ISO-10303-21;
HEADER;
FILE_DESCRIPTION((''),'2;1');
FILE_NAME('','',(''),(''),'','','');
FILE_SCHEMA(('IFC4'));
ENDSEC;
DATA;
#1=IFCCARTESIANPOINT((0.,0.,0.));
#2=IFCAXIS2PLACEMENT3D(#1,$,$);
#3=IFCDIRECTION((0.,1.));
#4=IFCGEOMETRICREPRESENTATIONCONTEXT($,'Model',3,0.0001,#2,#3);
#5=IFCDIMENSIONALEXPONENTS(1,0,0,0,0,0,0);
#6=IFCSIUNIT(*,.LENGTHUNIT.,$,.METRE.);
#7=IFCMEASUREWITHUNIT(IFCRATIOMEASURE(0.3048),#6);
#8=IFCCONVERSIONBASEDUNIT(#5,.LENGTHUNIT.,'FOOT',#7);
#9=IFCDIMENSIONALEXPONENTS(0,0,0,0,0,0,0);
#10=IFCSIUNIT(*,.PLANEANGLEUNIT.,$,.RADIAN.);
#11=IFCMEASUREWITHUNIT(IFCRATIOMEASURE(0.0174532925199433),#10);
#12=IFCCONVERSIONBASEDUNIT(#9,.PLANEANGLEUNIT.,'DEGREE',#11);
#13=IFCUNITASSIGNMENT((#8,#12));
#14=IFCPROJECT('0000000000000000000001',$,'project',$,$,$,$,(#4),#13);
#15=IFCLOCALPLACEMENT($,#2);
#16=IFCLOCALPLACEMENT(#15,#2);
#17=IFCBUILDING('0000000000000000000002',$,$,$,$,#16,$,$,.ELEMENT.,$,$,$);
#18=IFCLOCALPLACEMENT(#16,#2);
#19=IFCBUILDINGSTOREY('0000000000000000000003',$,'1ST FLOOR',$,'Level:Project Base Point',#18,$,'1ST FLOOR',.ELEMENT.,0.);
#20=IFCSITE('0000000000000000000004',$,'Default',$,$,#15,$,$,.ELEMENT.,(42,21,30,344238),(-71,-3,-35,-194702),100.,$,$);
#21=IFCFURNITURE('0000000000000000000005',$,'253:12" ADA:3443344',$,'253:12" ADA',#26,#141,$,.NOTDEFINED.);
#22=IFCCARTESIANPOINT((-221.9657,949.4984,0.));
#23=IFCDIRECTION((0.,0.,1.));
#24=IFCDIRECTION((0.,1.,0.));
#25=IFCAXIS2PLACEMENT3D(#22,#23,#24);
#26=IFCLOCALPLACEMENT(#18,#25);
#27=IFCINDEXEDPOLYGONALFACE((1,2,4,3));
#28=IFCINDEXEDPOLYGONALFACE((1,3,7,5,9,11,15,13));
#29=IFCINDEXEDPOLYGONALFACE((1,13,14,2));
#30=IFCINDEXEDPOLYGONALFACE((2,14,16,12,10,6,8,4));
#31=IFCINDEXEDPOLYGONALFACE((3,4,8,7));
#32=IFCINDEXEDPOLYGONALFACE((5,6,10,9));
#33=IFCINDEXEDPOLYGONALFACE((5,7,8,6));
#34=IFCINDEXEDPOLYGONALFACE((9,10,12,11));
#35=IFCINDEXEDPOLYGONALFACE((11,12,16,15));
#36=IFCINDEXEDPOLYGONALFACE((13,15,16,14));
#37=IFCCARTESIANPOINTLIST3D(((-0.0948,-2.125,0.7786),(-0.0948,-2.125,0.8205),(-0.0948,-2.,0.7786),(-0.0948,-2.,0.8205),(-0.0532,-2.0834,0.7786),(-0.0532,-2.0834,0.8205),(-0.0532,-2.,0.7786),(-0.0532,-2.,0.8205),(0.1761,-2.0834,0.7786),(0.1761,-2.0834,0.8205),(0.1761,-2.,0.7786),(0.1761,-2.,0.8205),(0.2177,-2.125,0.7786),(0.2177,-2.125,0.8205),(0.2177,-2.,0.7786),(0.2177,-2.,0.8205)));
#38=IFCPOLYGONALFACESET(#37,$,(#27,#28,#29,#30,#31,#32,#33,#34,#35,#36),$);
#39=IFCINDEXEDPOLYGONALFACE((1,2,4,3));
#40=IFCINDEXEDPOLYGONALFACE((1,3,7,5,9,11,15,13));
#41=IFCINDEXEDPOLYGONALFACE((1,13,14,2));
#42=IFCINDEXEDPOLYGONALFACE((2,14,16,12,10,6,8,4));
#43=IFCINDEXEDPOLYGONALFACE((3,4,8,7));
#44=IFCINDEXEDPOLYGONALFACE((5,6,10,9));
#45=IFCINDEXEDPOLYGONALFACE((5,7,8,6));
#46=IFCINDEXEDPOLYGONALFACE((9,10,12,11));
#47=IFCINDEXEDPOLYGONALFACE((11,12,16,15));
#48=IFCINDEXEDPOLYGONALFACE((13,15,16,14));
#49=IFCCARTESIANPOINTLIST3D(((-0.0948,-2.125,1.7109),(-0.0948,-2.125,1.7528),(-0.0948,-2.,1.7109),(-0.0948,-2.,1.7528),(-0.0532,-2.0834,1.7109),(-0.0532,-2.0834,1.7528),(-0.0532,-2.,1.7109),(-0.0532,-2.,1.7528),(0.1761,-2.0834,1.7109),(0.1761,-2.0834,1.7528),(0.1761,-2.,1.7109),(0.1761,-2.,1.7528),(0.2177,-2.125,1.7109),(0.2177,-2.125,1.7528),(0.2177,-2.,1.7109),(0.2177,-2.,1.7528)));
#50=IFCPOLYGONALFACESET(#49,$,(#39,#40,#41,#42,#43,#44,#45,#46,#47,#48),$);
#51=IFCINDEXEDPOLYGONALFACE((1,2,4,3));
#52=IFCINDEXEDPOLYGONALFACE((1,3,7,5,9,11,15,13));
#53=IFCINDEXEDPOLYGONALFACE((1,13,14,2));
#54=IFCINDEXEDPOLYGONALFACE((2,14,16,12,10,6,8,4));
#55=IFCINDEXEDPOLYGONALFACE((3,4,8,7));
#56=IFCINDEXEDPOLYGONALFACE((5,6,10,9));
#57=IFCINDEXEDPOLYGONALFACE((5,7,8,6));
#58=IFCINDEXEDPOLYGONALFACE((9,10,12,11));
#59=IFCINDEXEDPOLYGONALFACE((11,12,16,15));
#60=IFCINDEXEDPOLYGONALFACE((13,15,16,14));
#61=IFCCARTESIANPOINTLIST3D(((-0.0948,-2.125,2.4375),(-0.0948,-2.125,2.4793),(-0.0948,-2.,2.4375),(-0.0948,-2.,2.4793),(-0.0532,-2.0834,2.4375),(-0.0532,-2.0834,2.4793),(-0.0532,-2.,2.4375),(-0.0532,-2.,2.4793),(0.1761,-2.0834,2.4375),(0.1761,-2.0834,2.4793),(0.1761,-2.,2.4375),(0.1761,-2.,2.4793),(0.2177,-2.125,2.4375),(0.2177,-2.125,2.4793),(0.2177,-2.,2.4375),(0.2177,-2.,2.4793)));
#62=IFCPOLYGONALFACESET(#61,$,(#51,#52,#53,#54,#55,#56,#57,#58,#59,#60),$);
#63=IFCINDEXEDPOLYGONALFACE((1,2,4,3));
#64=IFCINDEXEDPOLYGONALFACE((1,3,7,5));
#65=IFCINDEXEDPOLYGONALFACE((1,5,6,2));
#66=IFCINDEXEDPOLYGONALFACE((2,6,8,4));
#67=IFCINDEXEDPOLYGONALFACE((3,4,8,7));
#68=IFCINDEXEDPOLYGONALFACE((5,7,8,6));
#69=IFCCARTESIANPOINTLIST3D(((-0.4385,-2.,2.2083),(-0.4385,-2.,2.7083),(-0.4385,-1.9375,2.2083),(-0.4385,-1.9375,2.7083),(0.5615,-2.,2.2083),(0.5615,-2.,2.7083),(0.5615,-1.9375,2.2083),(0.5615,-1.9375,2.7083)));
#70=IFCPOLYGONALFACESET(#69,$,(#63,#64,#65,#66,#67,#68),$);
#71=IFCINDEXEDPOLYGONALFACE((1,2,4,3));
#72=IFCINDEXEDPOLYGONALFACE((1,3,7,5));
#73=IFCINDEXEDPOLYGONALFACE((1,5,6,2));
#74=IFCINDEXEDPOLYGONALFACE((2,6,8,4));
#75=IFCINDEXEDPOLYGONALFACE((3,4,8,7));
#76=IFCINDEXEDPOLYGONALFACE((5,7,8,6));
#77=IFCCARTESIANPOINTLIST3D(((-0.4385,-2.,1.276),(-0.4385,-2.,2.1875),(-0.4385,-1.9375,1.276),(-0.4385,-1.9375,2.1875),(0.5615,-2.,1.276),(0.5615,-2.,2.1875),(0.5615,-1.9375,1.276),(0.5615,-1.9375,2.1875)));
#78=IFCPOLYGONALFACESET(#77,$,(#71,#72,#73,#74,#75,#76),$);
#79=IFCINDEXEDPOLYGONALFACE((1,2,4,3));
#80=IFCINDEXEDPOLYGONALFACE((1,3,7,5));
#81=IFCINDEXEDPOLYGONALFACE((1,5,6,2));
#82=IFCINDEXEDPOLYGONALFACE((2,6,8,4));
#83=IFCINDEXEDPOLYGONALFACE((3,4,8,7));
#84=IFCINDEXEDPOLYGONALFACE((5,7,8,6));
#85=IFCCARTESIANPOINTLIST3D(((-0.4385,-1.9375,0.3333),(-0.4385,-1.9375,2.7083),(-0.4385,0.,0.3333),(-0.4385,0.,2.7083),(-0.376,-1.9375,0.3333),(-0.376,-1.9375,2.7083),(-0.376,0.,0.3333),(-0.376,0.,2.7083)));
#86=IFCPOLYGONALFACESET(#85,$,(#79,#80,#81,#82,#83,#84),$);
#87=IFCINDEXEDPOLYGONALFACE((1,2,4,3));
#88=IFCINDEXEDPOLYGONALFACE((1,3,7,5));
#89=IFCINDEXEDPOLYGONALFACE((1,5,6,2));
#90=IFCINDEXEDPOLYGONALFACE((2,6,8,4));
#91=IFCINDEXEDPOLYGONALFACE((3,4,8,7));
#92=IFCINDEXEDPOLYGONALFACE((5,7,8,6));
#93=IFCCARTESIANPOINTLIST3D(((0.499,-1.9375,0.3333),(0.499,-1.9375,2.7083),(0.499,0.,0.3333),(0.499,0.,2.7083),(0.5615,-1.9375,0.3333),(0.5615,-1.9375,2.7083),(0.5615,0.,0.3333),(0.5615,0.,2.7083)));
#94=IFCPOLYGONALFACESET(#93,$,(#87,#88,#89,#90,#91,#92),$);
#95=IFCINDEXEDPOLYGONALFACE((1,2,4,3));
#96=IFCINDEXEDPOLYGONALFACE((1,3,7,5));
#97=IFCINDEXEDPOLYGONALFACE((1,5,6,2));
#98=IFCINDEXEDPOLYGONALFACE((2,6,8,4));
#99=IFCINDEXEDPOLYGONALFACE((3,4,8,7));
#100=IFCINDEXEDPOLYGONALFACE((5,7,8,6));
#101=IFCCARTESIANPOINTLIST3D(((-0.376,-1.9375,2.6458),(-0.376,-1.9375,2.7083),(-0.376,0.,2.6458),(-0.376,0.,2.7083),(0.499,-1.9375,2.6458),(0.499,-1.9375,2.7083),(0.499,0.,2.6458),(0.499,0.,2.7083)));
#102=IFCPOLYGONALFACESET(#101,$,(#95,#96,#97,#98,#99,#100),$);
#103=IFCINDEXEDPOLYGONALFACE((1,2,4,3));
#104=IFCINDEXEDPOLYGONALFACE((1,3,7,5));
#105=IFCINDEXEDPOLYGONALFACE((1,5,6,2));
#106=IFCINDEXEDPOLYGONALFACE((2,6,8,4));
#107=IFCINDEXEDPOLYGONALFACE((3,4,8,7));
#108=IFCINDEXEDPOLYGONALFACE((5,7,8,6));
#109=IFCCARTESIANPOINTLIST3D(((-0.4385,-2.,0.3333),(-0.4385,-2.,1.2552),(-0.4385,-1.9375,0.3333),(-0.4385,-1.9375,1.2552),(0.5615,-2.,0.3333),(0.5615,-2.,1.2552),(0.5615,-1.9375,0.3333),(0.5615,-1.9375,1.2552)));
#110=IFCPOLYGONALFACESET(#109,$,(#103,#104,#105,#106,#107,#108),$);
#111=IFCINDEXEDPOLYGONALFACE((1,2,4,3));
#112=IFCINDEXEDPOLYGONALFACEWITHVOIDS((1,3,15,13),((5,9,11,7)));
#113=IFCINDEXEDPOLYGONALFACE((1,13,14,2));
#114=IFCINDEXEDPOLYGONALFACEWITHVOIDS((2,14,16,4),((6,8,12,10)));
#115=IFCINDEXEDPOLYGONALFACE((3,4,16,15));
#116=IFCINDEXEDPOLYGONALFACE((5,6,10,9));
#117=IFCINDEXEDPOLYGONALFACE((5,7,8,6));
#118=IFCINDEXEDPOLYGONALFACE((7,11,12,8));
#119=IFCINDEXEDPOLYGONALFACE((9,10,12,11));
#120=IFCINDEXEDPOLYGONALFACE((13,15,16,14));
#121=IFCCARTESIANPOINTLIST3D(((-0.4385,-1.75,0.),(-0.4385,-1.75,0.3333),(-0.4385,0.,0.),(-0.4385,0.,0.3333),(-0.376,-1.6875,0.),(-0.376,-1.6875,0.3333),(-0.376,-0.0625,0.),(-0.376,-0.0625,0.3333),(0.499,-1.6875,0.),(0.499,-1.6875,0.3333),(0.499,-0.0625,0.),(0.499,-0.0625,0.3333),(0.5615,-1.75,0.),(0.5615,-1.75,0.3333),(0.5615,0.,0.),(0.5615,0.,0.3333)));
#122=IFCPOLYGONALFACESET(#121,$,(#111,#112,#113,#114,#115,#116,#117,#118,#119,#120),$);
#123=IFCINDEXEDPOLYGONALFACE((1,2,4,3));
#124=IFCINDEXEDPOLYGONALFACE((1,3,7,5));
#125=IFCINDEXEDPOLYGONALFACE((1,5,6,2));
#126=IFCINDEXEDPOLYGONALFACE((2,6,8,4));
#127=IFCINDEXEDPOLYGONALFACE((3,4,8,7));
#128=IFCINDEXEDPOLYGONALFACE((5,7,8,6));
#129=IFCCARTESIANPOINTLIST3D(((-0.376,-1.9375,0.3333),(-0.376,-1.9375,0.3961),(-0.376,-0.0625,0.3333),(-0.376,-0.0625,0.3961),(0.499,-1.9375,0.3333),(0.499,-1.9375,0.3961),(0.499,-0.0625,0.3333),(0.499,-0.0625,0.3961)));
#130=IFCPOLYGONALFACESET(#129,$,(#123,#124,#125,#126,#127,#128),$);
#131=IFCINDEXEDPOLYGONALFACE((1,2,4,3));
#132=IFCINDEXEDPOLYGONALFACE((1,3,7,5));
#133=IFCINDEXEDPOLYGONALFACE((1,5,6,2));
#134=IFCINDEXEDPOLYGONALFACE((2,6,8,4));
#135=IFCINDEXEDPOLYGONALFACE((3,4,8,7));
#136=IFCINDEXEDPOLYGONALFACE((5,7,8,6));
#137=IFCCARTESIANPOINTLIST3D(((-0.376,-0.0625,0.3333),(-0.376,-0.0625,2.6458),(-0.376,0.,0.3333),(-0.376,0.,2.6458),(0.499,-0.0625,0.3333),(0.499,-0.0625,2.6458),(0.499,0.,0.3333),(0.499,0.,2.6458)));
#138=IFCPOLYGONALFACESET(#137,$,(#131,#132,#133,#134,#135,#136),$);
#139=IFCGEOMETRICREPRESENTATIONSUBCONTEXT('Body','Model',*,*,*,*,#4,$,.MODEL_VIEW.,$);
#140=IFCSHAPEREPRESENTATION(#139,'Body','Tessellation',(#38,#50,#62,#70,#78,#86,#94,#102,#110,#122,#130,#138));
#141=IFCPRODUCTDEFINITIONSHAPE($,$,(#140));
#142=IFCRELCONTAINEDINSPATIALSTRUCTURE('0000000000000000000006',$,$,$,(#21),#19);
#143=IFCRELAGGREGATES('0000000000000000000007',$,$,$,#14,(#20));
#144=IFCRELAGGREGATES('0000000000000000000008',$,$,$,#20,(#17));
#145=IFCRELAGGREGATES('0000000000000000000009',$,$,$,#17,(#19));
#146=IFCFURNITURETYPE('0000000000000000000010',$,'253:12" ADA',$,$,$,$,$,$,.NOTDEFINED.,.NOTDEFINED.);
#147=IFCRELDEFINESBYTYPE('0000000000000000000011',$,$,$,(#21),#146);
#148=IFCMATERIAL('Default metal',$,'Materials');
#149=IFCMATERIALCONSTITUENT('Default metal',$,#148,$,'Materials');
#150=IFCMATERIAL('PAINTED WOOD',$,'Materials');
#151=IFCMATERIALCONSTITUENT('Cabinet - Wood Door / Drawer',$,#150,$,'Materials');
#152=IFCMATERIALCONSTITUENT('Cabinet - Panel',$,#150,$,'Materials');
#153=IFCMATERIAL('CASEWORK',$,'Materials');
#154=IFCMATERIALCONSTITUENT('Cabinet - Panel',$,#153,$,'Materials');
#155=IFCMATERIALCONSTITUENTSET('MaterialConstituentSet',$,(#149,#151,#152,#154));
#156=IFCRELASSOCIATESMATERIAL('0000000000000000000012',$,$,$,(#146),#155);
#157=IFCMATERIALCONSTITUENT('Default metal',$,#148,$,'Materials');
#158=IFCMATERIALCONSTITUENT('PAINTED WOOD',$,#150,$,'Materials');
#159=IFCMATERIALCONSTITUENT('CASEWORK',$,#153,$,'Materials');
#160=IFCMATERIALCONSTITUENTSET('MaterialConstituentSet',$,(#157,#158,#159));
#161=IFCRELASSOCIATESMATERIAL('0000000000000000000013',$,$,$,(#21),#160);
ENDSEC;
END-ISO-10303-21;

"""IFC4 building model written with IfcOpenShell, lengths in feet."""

from ifc_helpers import new_model, entity, si_unit, converted_unit, direction, frame, frame_2d, origin, origin_2d_with_axis, place, context, subcontext, project, spatial, polyline, rectangle, outline, extrude, source, transform, mapped, material, constituent, constituent_set, type_object, type_shapes, element, save


model = new_model("IFC4")

# Units and contexts
model_context = context("Model", 3, precision=0.0001, world=origin(), true_north=direction((0.0, 1.0)))
body_context = subcontext(model_context, "Body", "Model", "MODEL_VIEW")
ifc_project = project(units=[converted_unit("LENGTHUNIT", "FOOT", entity("IfcRatioMeasure", 0.3048), si_unit("LENGTHUNIT", "METRE"), dimensions=[1, 0, 0, 0, 0, 0, 0]), converted_unit("PLANEANGLEUNIT", "DEGREE", entity("IfcRatioMeasure", 0.0174532925199433), si_unit("PLANEANGLEUNIT", "RADIAN"), dimensions=[0, 0, 0, 0, 0, 0, 0])], contexts=[model_context])

# Site, building, storey
site_placement = place(None, origin())
site = spatial("IfcSite", under=ifc_project, at=site_placement, Name="Default", CompositionType="ELEMENT", RefLatitude=(42, 21, 30, 344238), RefLongitude=(-71, -3, -35, -194702), RefElevation=100.0)
building_placement = place(site_placement, origin())
building = spatial("IfcBuilding", under=site, at=building_placement, CompositionType="ELEMENT")
storey_placement = place(building_placement, origin())
storey = spatial("IfcBuildingStorey", under=building, at=storey_placement, Name="1ST FLOOR", ObjectType="Level:Project Base Point", LongName="1ST FLOOR", CompositionType="ELEMENT", Elevation=0.0)

# Furniture
ifc_material_1 = material(Name="Default metal", Category="Materials")
ifc_constituent_1 = constituent(ifc_material_1, Name="Default metal", Category="Materials")
ifc_material_2 = material(Name="PAINTED WOOD", Category="Materials")
ifc_constituent_2 = constituent(ifc_material_2, Name="PAINTED WOOD", Category="Materials")
ifc_material_3 = material(Name="CASEWORK", Category="Materials")
ifc_constituent_3 = constituent(ifc_material_3, Name="CASEWORK", Category="Materials")
ifc_constituent_set_1 = constituent_set(constituents=[ifc_constituent_1, ifc_constituent_2, ifc_constituent_3], Name="MaterialConstituentSet")
ifc_constituent_4 = constituent(ifc_material_1, Name="Default metal", Category="Materials")
ifc_constituent_5 = constituent(ifc_material_2, Name="Cabinet - Wood Door / Drawer", Category="Materials")
ifc_constituent_6 = constituent(ifc_material_2, Name="Cabinet - Panel", Category="Materials")
ifc_constituent_7 = constituent(ifc_material_3, Name="Cabinet - Panel", Category="Materials")
ifc_constituent_set_2 = constituent_set(constituents=[ifc_constituent_4, ifc_constituent_5, ifc_constituent_6, ifc_constituent_7], Name="MaterialConstituentSet")
furniture_type_1 = type_object("IfcFurnitureType", Name="253:12\" ADA", AssemblyPlace="NOTDEFINED", PredefinedType="NOTDEFINED", material=ifc_constituent_set_2)
shared_shape_1 = source(origin(), body_context, "Body", "SweptSolid", [
    extrude(outline(polyline([(-0.0521, -0.1562), (0.0729, -0.1562), (0.0729, 0.1562), (-0.0521, 0.1562), (-0.0521, 0.1146), (0.0313, 0.1146), (0.0313, -0.1146), (-0.0521, -0.1146), (-0.0521, -0.1562)])), frame((0.0615, -2.0521, 0.7786), z_axis=(0.0, 0.0, 1.0), x_axis=(0.0, -1.0, 0.0)), (0.0, 0.0, 1.0), 0.0418),
    extrude(outline(polyline([(-0.0521, -0.1562), (0.0729, -0.1562), (0.0729, 0.1562), (-0.0521, 0.1562), (-0.0521, 0.1146), (0.0313, 0.1146), (0.0313, -0.1146), (-0.0521, -0.1146), (-0.0521, -0.1562)])), frame((0.0615, -2.0521, 1.7109), z_axis=(0.0, 0.0, 1.0), x_axis=(0.0, -1.0, 0.0)), (0.0, 0.0, 1.0), 0.0418),
    extrude(outline(polyline([(-0.0521, -0.1562), (0.0729, -0.1562), (0.0729, 0.1562), (-0.0521, 0.1562), (-0.0521, 0.1146), (0.0313, 0.1146), (0.0313, -0.1146), (-0.0521, -0.1146), (-0.0521, -0.1562)])), frame((0.0615, -2.0521, 2.4375), z_axis=(0.0, 0.0, 1.0), x_axis=(0.0, -1.0, 0.0)), (0.0, 0.0, 1.0), 0.0418),
    extrude(rectangle(XDim=0.0625, YDim=1.0, at=origin_2d_with_axis()), frame((0.0615, -1.9688, 2.2083), z_axis=(0.0, 0.0, 1.0), x_axis=(0.0, 1.0, 0.0)), (0.0, 0.0, 1.0), 0.5),
    extrude(rectangle(XDim=0.0625, YDim=1.0, at=origin_2d_with_axis()), frame((0.0615, -1.9688, 1.276), z_axis=(0.0, 0.0, 1.0), x_axis=(0.0, 1.0, 0.0)), (0.0, 0.0, 1.0), 0.9115),
    extrude(rectangle(XDim=0.0625, YDim=1.9375, at=frame_2d((0.0, 0.0), x_axis=(1.0, 0.0))), frame((-0.4073, -0.9687, 0.3333)), (0.0, 0.0, 1.0), 2.375),
    extrude(rectangle(XDim=0.0625, YDim=1.9375, at=frame_2d((0.0, 0.0), x_axis=(1.0, 0.0))), frame((0.5302, -0.9687, 0.3333)), (0.0, 0.0, 1.0), 2.375),
    extrude(rectangle(XDim=0.875, YDim=1.9375, at=origin_2d_with_axis()), frame((0.0615, -0.9688, 2.6458), z_axis=(0.0, 0.0, 1.0), x_axis=(-1.0, 0.0, 0.0)), (0.0, 0.0, 1.0), 0.0625),
    extrude(rectangle(XDim=0.0625, YDim=1.0, at=origin_2d_with_axis()), frame((0.0615, -1.9688, 0.3333), z_axis=(0.0, 0.0, 1.0), x_axis=(0.0, 1.0, 0.0)), (0.0, 0.0, 1.0), 0.9219),
    extrude(outline(polyline([(-0.5, -0.875), (0.5, -0.875), (0.5, 0.875), (-0.5, 0.875), (-0.5, -0.875)]), holes=[polyline([(-0.4375, -0.8125), (-0.4375, 0.8125), (0.4375, 0.8125), (0.4375, -0.8125), (-0.4375, -0.8125)])]), frame((0.0615, -0.875, 0.0)), (0.0, 0.0, 1.0), 0.3333),
    extrude(rectangle(XDim=0.875, YDim=1.875, at=frame_2d((0.0, 0.0), x_axis=(1.0, 0.0))), frame((0.0615, -1.0, 0.3333), z_axis=(0.0, 0.0, 1.0), x_axis=(-1.0, 0.0, 0.0)), (0.0, 0.0, 1.0), 0.0627),
    extrude(rectangle(XDim=0.0625, YDim=0.875, at=origin_2d_with_axis()), frame((0.0615, -0.0312, 0.3333), z_axis=(0.0, 0.0, 1.0), x_axis=(0.0, 1.0, 0.0)), (0.0, 0.0, 1.0), 2.3125),
])
type_shapes(furniture_type_1, [shared_shape_1])
furniture_1_placement = place(storey_placement, frame((-221.9657, 949.4984, 0.0), z_axis=(0.0, 0.0, 1.0), x_axis=(0.0, 1.0, 0.0)))
element("IfcFurniture", 1, at=furniture_1_placement, inside=storey, type_object=furniture_type_1, material=ifc_constituent_set_1, Name="253:12\" ADA:3443344", ObjectType="253:12\" ADA", PredefinedType="NOTDEFINED", context=body_context, shape_type="MappedRepresentation", body=[
    mapped(shared_shape_1, transform((0.0, 0.0, 0.0), scale=1.0)),
])

save(model, "model.ifc")
